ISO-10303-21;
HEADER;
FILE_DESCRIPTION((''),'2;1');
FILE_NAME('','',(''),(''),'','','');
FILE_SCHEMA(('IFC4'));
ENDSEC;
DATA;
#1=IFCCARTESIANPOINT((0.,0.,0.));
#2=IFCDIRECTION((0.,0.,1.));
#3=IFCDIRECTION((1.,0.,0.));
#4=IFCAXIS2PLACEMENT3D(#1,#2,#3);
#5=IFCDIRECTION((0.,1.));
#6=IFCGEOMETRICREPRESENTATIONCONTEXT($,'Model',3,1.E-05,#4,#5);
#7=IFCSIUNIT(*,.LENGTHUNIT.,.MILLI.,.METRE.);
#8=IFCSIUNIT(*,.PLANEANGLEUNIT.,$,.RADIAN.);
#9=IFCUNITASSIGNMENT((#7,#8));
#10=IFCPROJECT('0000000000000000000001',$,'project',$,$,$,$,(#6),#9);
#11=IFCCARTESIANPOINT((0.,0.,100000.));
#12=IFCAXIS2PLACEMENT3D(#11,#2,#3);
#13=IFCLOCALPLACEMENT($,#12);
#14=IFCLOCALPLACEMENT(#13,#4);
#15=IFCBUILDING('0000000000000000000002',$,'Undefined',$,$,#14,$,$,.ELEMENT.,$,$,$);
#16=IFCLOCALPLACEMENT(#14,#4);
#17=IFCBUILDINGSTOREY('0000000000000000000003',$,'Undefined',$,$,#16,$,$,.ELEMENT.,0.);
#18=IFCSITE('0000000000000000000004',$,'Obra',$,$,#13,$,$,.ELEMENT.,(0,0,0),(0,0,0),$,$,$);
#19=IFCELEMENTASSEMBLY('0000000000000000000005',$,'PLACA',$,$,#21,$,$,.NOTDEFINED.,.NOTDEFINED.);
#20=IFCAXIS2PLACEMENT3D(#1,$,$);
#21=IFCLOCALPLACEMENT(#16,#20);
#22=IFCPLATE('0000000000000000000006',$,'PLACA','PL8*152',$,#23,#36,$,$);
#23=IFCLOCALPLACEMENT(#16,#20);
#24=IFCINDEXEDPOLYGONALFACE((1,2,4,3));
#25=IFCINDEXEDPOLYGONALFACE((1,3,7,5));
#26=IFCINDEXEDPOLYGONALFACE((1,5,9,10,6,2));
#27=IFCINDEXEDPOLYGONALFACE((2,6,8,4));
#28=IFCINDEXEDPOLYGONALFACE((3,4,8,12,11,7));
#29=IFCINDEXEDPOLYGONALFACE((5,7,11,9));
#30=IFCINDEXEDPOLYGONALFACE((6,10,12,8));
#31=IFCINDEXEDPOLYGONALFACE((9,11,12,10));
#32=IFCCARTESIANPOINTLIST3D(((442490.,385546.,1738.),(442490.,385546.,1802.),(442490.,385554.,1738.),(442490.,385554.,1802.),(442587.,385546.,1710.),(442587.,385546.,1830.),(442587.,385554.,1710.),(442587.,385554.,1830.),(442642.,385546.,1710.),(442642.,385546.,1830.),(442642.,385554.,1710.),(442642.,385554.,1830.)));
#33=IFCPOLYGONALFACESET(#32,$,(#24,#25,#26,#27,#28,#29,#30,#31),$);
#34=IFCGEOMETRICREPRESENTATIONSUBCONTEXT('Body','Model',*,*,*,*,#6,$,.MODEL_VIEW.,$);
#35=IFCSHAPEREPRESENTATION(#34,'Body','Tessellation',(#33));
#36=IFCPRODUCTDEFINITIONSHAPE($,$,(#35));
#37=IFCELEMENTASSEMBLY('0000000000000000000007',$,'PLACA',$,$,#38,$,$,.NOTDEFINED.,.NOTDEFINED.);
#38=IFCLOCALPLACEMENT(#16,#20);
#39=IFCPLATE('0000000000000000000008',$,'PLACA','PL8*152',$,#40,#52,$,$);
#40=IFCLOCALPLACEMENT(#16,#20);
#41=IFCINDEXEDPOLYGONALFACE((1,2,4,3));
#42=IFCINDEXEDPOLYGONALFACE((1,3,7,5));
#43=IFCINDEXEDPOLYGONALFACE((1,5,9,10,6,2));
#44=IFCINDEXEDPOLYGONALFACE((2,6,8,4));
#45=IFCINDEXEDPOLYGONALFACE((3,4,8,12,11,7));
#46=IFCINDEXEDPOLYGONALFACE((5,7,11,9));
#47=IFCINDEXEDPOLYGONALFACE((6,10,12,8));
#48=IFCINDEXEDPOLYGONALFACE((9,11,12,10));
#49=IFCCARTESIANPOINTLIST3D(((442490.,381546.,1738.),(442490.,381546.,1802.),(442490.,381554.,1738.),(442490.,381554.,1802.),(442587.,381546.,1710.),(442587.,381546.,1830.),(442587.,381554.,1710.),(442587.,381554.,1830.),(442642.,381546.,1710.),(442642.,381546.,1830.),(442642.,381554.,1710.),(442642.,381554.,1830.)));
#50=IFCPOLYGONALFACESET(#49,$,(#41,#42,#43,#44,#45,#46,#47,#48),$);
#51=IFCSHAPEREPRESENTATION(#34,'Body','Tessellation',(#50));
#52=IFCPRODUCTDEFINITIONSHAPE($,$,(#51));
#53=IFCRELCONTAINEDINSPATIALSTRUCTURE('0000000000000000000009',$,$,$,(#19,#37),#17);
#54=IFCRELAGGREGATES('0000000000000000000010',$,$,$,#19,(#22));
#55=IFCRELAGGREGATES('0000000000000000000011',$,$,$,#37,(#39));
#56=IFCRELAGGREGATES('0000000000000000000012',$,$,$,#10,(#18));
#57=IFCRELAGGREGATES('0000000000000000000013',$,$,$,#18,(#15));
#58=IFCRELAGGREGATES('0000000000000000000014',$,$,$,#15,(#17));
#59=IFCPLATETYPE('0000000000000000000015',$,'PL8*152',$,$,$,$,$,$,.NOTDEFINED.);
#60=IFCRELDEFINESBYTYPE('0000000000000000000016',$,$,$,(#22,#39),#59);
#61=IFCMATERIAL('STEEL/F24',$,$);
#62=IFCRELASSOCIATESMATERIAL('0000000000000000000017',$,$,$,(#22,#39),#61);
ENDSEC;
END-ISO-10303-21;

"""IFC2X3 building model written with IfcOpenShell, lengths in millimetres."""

from ifc_helpers import new_model, si_unit, direction, frame, origin_with_axes, place, context, subcontext, project, spatial, polyline, outline, extrude, material, type_object, element, aggregate, save


model = new_model("IFC2X3")

# Units and contexts
model_context = context("Model", 3, precision=1e-05, world=origin_with_axes(), true_north=direction((0.0, 1.0)))
body_context = subcontext(model_context, "Body", "Model", "MODEL_VIEW")
ifc_project = project(units=[si_unit("LENGTHUNIT", "METRE", prefix="MILLI"), si_unit("PLANEANGLEUNIT", "RADIAN")], contexts=[model_context])

# Site, building, storey
site_placement = place(None, frame((0.0, 0.0, 100000.0), z_axis=(0.0, 0.0, 1.0), x_axis=(1.0, 0.0, 0.0)))
site = spatial("IfcSite", under=ifc_project, at=site_placement, Name="Obra", CompositionType="ELEMENT", RefLatitude=(0, 0, 0), RefLongitude=(0, 0, 0))
building_placement = place(site_placement, origin_with_axes())
building = spatial("IfcBuilding", under=site, at=building_placement, Name="Undefined", CompositionType="ELEMENT")
storey_placement = place(building_placement, origin_with_axes())
storey = spatial("IfcBuildingStorey", under=building, at=storey_placement, Name="Undefined", CompositionType="ELEMENT", Elevation=0.0)

# Shared definitions
ifc_material_1 = material(Name="STEEL/F24")

# Element assemblies, plates
plate_type_1 = type_object("IfcPlateType", Name="PL8*152", PredefinedType="NOTDEFINED")
assembly_1_placement = place(storey_placement, origin_with_axes())
assembly_1 = element("IfcElementAssembly", 1, at=assembly_1_placement, inside=storey, Name="PLACA", AssemblyPlace="NOTDEFINED", PredefinedType="NOTDEFINED")
plate_1_placement = place(assembly_1_placement, frame((442587.0, 385550.0, 1830.0), z_axis=(0.0, 1.0, 0.0), x_axis=(1.0, 0.0, 0.0)))
plate_1 = element("IfcPlate", 2, at=plate_1_placement, type_object=plate_type_1, material=ifc_material_1, Name="PLACA", Description="PL8*152", context=body_context, shape_type="SweptSolid", body=[
    extrude(outline(polyline([(0.0, 0.0), (55.0, 0.0), (55.0, 120.0), (0.0, 120.0), (-97.0, 92.0), (-97.0, 28.0), (0.0, 0.0)])), frame((0.0, 0.0, -4.0), z_axis=(0.0, 0.0, 1.0), x_axis=(1.0, 0.0, 0.0)), (0.0, 0.0, 1.0), 8.0),
])
aggregate(assembly_1, [plate_1])
assembly_2_placement = place(storey_placement, origin_with_axes())
assembly_2 = element("IfcElementAssembly", 3, at=assembly_2_placement, inside=storey, Name="PLACA", AssemblyPlace="NOTDEFINED", PredefinedType="NOTDEFINED")
plate_2_placement = place(assembly_2_placement, frame((442587.0, 381550.0, 1830.0), z_axis=(0.0, 1.0, 0.0), x_axis=(1.0, 0.0, 0.0)))
plate_2 = element("IfcPlate", 4, at=plate_2_placement, type_object=plate_type_1, material=ifc_material_1, Name="PLACA", Description="PL8*152", context=body_context, shape_type="SweptSolid", body=[
    extrude(outline(polyline([(0.0, 0.0), (55.0, 0.0), (55.0, 120.0), (0.0, 120.0), (-97.0, 92.0), (-97.0, 28.0), (0.0, 0.0)])), frame((0.0, 0.0, -4.0), z_axis=(0.0, 0.0, 1.0), x_axis=(1.0, 0.0, 0.0)), (0.0, 0.0, 1.0), 8.0),
])
aggregate(assembly_2, [plate_2])

save(model, "model.ifc")
